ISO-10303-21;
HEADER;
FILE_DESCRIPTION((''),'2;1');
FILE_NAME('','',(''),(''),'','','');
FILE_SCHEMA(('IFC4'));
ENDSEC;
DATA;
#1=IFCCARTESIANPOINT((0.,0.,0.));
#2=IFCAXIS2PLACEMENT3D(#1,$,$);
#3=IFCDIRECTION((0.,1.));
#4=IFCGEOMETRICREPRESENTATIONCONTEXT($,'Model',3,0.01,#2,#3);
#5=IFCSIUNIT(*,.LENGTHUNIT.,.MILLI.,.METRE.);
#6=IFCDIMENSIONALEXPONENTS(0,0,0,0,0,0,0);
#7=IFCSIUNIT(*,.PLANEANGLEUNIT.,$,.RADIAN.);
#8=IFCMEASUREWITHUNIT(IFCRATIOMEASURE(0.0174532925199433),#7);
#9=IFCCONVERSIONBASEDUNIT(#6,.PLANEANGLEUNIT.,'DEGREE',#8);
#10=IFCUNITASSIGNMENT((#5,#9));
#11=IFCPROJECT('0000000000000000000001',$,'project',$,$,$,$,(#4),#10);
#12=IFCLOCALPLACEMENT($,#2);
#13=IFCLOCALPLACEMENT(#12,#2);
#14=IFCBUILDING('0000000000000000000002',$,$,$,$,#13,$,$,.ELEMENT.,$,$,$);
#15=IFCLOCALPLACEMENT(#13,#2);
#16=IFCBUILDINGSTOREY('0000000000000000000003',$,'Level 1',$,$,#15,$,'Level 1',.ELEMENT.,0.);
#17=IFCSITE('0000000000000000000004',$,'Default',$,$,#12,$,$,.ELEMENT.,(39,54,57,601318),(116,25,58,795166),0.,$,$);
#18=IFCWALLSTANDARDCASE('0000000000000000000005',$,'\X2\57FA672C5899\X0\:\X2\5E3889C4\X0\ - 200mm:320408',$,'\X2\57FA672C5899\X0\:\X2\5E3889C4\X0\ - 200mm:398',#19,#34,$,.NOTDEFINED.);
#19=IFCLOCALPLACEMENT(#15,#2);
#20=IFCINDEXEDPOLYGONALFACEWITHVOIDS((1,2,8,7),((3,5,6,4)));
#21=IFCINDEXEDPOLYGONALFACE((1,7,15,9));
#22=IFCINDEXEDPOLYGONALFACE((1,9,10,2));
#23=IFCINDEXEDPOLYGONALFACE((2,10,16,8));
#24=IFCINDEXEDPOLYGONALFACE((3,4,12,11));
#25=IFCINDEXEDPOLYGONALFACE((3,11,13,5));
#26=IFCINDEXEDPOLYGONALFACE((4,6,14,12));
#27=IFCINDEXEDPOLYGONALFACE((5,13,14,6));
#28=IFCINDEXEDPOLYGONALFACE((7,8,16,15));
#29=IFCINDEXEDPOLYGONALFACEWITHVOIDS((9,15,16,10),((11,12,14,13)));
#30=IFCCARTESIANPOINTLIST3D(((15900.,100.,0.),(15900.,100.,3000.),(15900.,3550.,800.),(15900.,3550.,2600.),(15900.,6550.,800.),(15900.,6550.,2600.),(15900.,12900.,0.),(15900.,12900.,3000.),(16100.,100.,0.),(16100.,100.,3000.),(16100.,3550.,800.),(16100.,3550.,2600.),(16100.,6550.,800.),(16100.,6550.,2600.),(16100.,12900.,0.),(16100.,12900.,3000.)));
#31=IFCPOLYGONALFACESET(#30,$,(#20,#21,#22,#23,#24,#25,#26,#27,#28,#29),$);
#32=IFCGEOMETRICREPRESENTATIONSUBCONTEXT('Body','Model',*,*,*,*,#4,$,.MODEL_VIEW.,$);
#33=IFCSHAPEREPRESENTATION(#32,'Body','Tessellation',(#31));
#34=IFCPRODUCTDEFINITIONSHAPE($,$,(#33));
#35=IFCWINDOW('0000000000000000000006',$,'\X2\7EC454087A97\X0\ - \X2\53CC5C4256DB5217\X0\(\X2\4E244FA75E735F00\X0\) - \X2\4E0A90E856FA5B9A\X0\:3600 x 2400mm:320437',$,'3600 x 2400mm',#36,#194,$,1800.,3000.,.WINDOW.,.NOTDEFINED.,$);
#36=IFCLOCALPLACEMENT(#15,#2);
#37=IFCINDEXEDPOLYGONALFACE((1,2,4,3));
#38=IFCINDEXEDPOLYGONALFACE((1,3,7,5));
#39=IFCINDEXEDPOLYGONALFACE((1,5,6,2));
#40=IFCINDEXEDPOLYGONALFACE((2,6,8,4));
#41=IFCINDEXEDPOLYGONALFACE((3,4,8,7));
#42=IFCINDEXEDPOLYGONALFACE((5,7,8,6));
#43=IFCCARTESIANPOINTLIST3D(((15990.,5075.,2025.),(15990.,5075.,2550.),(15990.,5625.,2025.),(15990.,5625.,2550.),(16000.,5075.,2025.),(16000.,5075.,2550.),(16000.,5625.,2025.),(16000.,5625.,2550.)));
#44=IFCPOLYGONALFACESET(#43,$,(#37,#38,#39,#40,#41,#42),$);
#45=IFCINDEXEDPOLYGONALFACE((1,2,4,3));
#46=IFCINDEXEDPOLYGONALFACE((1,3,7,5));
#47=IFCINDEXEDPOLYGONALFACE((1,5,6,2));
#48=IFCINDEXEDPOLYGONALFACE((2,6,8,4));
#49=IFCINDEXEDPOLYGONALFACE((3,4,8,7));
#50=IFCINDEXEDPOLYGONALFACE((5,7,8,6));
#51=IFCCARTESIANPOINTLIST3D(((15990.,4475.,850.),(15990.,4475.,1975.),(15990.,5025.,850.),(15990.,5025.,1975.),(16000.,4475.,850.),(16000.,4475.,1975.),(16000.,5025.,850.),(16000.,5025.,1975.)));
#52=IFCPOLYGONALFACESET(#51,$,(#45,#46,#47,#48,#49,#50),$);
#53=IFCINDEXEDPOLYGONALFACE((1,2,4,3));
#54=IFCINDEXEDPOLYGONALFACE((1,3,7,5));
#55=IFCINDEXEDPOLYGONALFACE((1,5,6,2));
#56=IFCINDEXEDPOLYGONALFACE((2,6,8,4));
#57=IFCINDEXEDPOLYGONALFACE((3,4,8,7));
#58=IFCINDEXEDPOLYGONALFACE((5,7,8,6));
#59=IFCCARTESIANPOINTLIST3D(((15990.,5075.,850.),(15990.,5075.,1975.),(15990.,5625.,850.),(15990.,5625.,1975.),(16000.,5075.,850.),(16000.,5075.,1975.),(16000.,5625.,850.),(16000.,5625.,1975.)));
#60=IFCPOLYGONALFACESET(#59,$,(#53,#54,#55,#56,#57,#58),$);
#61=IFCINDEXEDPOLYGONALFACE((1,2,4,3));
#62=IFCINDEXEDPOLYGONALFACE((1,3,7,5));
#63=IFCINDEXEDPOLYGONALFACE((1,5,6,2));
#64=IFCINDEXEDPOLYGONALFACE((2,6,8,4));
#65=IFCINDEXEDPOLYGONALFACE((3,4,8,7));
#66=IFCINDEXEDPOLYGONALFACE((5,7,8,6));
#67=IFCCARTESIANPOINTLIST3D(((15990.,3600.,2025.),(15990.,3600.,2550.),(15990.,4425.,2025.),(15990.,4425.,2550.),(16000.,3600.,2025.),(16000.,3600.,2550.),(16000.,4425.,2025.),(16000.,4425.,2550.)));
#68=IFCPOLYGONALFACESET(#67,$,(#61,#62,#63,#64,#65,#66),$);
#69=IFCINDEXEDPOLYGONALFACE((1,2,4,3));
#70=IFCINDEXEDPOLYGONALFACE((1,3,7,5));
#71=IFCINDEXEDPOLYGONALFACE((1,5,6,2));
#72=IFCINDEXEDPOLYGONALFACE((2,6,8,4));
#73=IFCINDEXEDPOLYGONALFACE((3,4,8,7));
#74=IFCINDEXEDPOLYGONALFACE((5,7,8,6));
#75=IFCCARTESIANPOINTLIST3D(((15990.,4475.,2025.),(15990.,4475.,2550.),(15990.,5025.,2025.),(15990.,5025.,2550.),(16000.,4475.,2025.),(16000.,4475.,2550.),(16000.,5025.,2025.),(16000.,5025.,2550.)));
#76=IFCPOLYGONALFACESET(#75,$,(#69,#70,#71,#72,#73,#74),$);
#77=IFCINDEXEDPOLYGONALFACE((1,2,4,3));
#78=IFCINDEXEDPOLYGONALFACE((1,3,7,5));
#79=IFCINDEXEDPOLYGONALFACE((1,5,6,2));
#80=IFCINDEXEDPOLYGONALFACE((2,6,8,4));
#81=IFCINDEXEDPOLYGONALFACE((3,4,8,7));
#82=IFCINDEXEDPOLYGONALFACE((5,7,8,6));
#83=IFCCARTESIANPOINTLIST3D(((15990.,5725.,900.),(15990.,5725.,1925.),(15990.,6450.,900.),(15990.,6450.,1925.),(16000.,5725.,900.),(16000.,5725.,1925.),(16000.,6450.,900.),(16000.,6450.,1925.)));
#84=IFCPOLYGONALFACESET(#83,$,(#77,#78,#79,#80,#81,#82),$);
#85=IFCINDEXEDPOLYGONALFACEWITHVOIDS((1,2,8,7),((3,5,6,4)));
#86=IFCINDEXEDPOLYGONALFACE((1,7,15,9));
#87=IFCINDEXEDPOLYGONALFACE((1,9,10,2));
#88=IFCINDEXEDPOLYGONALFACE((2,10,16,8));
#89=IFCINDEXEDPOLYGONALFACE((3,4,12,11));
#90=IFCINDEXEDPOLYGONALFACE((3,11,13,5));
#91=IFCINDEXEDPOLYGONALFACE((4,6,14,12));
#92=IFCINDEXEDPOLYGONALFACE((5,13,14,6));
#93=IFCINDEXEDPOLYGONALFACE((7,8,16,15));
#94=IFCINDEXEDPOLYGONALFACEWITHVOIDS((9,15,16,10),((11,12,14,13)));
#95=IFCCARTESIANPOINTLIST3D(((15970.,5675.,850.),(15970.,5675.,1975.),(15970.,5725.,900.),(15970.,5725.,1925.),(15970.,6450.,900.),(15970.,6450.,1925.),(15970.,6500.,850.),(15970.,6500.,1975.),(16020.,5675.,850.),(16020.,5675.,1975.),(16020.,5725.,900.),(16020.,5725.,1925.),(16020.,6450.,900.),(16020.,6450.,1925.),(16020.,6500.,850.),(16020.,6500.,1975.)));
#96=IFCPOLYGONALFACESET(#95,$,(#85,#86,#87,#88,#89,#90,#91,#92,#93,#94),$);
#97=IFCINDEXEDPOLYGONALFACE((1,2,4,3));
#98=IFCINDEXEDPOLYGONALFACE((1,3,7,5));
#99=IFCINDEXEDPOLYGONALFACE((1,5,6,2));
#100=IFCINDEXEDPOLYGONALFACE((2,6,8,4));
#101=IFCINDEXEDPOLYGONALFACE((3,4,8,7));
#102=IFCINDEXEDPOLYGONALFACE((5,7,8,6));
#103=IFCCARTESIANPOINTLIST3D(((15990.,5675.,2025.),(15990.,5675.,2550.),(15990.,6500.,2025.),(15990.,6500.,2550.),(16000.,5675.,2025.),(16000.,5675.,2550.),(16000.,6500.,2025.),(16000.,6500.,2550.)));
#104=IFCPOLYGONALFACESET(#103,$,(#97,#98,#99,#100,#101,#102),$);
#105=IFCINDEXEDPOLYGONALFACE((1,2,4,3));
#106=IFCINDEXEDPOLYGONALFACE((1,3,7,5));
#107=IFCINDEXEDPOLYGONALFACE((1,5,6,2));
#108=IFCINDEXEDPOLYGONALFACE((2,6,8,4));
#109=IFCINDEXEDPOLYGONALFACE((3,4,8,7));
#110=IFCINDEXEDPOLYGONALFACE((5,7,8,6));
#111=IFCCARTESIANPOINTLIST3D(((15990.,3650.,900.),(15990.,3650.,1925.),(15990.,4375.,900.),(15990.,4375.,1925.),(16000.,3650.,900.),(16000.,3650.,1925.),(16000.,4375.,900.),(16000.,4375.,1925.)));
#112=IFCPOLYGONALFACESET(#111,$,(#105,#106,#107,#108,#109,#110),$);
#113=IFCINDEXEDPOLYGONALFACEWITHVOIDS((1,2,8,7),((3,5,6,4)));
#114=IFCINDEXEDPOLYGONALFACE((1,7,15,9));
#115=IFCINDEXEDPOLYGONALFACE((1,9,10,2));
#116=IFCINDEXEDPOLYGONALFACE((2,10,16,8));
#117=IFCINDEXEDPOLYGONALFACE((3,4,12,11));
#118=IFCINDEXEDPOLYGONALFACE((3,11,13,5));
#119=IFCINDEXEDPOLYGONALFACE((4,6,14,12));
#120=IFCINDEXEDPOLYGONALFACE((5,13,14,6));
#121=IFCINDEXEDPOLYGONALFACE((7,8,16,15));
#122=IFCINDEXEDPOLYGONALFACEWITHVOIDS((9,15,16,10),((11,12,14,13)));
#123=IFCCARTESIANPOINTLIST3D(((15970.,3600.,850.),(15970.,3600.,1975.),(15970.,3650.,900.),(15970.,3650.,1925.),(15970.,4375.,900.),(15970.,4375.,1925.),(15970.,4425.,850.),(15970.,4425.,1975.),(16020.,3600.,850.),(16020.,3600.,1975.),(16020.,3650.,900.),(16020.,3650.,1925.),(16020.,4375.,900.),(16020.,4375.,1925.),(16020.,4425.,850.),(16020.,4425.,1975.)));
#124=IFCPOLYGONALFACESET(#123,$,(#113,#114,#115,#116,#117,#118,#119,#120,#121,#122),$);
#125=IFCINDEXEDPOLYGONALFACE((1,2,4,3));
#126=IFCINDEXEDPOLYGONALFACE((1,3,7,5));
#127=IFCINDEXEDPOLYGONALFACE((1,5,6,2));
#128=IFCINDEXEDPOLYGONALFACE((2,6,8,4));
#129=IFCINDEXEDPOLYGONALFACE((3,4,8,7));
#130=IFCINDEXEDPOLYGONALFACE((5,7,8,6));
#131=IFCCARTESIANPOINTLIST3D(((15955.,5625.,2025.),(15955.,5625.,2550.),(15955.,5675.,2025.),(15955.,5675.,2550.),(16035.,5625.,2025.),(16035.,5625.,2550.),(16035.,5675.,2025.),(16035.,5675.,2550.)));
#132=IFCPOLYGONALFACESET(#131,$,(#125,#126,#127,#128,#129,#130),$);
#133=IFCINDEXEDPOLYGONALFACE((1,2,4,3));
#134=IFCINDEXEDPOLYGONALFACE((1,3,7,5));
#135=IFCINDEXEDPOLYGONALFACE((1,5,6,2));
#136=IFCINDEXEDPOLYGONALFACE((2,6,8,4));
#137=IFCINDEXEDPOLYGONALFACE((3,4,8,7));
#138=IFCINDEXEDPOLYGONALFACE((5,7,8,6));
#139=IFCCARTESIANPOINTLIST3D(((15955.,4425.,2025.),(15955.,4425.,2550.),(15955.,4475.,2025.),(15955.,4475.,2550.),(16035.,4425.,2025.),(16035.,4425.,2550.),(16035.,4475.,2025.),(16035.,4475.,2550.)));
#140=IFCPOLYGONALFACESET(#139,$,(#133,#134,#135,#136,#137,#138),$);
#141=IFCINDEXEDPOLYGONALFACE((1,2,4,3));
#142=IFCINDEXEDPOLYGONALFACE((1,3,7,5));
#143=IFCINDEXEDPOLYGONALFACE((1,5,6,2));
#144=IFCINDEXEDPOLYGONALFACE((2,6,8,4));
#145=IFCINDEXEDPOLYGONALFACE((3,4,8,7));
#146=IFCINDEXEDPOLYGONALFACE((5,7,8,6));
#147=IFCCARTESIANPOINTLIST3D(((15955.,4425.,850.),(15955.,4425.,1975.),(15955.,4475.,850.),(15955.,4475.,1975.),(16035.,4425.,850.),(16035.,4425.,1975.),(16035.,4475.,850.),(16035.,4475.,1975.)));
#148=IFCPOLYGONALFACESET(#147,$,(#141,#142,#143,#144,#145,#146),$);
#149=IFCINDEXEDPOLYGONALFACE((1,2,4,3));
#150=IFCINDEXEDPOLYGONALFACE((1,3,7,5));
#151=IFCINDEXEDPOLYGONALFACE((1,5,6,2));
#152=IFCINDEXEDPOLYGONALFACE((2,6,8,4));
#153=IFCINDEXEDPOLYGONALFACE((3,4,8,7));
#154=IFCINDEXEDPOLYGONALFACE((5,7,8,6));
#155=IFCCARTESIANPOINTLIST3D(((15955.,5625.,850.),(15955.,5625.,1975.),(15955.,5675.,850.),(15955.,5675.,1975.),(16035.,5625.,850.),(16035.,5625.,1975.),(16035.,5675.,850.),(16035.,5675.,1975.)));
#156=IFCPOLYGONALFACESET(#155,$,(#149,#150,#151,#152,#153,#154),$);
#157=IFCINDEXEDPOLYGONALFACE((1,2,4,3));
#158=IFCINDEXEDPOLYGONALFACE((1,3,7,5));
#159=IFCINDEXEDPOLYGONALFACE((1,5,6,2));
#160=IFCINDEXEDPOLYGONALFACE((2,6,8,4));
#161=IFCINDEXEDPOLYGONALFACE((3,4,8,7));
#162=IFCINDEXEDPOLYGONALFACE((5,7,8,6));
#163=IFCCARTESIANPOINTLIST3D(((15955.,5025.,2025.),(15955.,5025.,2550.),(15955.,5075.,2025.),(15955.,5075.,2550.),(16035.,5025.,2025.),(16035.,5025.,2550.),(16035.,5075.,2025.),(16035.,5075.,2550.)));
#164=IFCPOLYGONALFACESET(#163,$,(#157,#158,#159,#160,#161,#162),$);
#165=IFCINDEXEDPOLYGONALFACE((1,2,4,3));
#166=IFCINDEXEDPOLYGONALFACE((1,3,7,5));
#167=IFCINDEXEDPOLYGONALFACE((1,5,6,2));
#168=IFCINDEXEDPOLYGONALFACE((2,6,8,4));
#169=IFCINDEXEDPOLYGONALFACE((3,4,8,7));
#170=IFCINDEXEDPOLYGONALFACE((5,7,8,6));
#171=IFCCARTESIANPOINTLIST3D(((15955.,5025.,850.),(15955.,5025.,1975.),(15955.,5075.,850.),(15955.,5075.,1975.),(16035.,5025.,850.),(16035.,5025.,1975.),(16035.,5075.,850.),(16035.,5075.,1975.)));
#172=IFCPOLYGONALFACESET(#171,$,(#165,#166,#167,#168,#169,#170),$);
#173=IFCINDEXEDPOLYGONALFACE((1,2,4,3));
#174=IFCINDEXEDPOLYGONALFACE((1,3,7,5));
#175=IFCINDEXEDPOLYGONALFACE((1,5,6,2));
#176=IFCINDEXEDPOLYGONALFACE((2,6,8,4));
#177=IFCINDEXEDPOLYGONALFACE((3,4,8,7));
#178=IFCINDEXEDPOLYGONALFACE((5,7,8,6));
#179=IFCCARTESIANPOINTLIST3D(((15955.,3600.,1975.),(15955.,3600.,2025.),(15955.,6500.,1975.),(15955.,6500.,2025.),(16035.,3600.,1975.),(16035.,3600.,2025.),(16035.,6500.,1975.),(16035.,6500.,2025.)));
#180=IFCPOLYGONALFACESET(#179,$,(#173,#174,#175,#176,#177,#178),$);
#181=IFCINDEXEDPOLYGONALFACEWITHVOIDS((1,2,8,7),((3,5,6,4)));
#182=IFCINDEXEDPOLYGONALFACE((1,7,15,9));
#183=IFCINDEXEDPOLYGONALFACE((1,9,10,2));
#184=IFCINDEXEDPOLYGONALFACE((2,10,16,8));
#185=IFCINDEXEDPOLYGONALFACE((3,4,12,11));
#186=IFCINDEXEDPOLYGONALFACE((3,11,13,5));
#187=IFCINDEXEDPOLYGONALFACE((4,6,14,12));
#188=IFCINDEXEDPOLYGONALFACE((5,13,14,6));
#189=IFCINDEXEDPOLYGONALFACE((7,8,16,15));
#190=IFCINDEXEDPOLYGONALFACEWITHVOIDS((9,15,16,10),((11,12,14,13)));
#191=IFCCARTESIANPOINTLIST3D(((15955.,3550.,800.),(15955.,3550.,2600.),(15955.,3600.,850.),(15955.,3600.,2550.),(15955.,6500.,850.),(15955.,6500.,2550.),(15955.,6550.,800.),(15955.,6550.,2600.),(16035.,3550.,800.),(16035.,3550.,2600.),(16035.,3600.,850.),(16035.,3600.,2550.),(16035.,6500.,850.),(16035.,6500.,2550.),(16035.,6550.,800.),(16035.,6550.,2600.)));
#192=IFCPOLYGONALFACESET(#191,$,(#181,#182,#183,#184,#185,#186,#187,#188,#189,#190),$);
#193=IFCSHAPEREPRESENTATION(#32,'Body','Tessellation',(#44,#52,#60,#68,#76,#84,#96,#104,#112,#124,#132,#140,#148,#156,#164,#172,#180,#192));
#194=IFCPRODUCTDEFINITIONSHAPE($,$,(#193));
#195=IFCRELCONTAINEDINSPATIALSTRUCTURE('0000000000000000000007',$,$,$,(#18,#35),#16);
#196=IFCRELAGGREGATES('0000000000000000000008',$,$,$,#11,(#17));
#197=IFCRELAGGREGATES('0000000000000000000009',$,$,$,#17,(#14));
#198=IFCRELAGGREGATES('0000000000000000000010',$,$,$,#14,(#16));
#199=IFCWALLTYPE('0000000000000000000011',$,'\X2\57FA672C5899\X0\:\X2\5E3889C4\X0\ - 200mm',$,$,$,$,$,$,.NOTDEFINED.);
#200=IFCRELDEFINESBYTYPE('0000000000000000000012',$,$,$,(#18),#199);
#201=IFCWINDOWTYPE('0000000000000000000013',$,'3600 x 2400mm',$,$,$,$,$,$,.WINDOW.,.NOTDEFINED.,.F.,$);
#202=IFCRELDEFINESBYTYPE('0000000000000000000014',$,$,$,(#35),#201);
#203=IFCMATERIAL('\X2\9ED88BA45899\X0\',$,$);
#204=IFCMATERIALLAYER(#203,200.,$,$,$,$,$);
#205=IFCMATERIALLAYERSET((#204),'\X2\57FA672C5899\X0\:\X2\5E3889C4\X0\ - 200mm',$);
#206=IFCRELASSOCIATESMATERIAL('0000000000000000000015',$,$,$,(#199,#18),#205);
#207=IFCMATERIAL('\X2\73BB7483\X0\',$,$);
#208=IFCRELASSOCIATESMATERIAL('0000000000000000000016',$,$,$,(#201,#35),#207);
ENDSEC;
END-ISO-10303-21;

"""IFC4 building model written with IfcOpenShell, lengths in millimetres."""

from ifc_helpers import new_model, entity, si_unit, converted_unit, direction, frame, frame_2d, origin, origin_2d_with_axis, place, context, subcontext, project, spatial, polyline, rectangle, outline, extrude, source, transform, mapped, material, layer, layer_set, layer_usage, type_object, type_shapes, element, fill, save


model = new_model("IFC4")

# Units and contexts
model_context = context("Model", 3, precision=0.01, world=origin(), true_north=direction((0.0, 1.0)))
body_context = subcontext(model_context, "Body", "Model", "MODEL_VIEW")
ifc_project = project(units=[si_unit("LENGTHUNIT", "METRE", prefix="MILLI"), converted_unit("PLANEANGLEUNIT", "DEGREE", entity("IfcRatioMeasure", 0.0174532925199433), si_unit("PLANEANGLEUNIT", "RADIAN"), dimensions=[0, 0, 0, 0, 0, 0, 0])], contexts=[model_context])

# Site, building, storey
site_placement = place(None, origin())
site = spatial("IfcSite", under=ifc_project, at=site_placement, Name="Default", CompositionType="ELEMENT", RefLatitude=(39, 54, 57, 601318), RefLongitude=(116, 25, 58, 795166), RefElevation=0.0)
building_placement = place(site_placement, origin())
building = spatial("IfcBuilding", under=site, at=building_placement, CompositionType="ELEMENT")
storey_placement = place(building_placement, origin())
storey = spatial("IfcBuildingStorey", under=building, at=storey_placement, Name="Level 1", LongName="Level 1", CompositionType="ELEMENT", Elevation=0.0)

# Shared definitions
ifc_material_1 = material(Name="默认墙")
ifc_layer = layer(ifc_material_1, 200.0)
ifc_layer_set = layer_set([ifc_layer], Name="基本墙:常规 - 200mm")
wall_type = type_object("IfcWallType", Name="基本墙:常规 - 200mm", PredefinedType="NOTDEFINED", material=ifc_layer_set)
ifc_material_2 = material(Name="玻璃")
window_type = type_object("IfcWindowType", Name="3600 x 2400mm", ParameterTakesPrecedence=False, PartitioningType="NOTDEFINED", PredefinedType="WINDOW", material=ifc_material_2)
shared_shape_1 = source(origin(), body_context, "Body", "SweptSolid", [
    extrude(rectangle(XDim=10.0, YDim=550.0, at=origin_2d_with_axis()), frame((1200.0, 95.0, 1225.0), z_axis=(0.0, 0.0, 1.0), x_axis=(0.0, 1.0, 0.0)), (0.0, 0.0, 1.0), 525.0),
    extrude(rectangle(XDim=10.0, YDim=550.0, at=origin_2d_with_axis()), frame((1800.0, 95.0, 50.0), z_axis=(0.0, 0.0, 1.0), x_axis=(0.0, 1.0, 0.0)), (0.0, 0.0, 1.0), 1125.0),
    extrude(rectangle(XDim=10.0, YDim=550.0, at=origin_2d_with_axis()), frame((1200.0, 95.0, 50.0), z_axis=(0.0, 0.0, 1.0), x_axis=(0.0, 1.0, 0.0)), (0.0, 0.0, 1.0), 1125.0),
    extrude(rectangle(XDim=10.0, YDim=825.0, at=origin_2d_with_axis()), frame((2537.5, 95.0, 1225.0), z_axis=(0.0, 0.0, 1.0), x_axis=(0.0, 1.0, 0.0)), (0.0, 0.0, 1.0), 525.0),
    extrude(rectangle(XDim=10.0, YDim=550.0, at=origin_2d_with_axis()), frame((1800.0, 95.0, 1225.0), z_axis=(0.0, 0.0, 1.0), x_axis=(0.0, 1.0, 0.0)), (0.0, 0.0, 1.0), 525.0),
    extrude(rectangle(XDim=10.0, YDim=725.0, at=origin_2d_with_axis()), frame((462.5, 95.0, 100.0), z_axis=(0.0, 0.0, 1.0), x_axis=(0.0, 1.0, 0.0)), (0.0, 0.0, 1.0), 1025.0),
    extrude(outline(polyline([(-562.5, -412.5), (562.5, -412.5), (562.5, 412.5), (-562.5, 412.5), (-562.5, -412.5)]), holes=[polyline([(512.5, -362.5), (-512.5, -362.5), (-512.5, 362.5), (512.5, 362.5), (512.5, -362.5)])]), frame((462.5, 70.0, 612.5), z_axis=(0.0, 1.0, 0.0), x_axis=(0.0, 0.0, -1.0)), (0.0, 0.0, 1.0), 50.0),
    extrude(rectangle(XDim=10.0, YDim=825.0, at=origin_2d_with_axis()), frame((462.5, 95.0, 1225.0), z_axis=(0.0, 0.0, 1.0), x_axis=(0.0, 1.0, 0.0)), (0.0, 0.0, 1.0), 525.0),
    extrude(rectangle(XDim=10.0, YDim=725.0, at=origin_2d_with_axis()), frame((2537.5, 95.0, 100.0), z_axis=(0.0, 0.0, 1.0), x_axis=(0.0, 1.0, 0.0)), (0.0, 0.0, 1.0), 1025.0),
    extrude(outline(polyline([(-562.5, -412.5), (562.5, -412.5), (562.5, 412.5), (-562.5, 412.5), (-562.5, -412.5)]), holes=[polyline([(512.5, -362.5), (-512.5, -362.5), (-512.5, 362.5), (512.5, 362.5), (512.5, -362.5)])]), frame((2537.5, 70.0, 612.5), z_axis=(0.0, 1.0, 0.0), x_axis=(0.0, 0.0, -1.0)), (0.0, 0.0, 1.0), 50.0),
    extrude(rectangle(XDim=80.0, YDim=50.0, at=origin_2d_with_axis()), frame((900.0, 95.0, 1225.0), z_axis=(0.0, 0.0, 1.0), x_axis=(0.0, -1.0, 0.0)), (0.0, 0.0, 1.0), 525.0),
    extrude(rectangle(XDim=80.0, YDim=50.0, at=origin_2d_with_axis()), frame((2100.0, 95.0, 1225.0), z_axis=(0.0, 0.0, 1.0), x_axis=(0.0, -1.0, 0.0)), (0.0, 0.0, 1.0), 525.0),
    extrude(rectangle(XDim=80.0, YDim=50.0, at=origin_2d_with_axis()), frame((2100.0, 95.0, 50.0), z_axis=(0.0, 0.0, 1.0), x_axis=(0.0, -1.0, 0.0)), (0.0, 0.0, 1.0), 1125.0),
    extrude(rectangle(XDim=80.0, YDim=50.0, at=origin_2d_with_axis()), frame((900.0, 95.0, 50.0), z_axis=(0.0, 0.0, 1.0), x_axis=(0.0, -1.0, 0.0)), (0.0, 0.0, 1.0), 1125.0),
    extrude(rectangle(XDim=80.0, YDim=50.0, at=origin_2d_with_axis()), frame((1500.0, 95.0, 1225.0), z_axis=(0.0, 0.0, 1.0), x_axis=(0.0, -1.0, 0.0)), (0.0, 0.0, 1.0), 525.0),
    extrude(rectangle(XDim=80.0, YDim=50.0, at=origin_2d_with_axis()), frame((1500.0, 95.0, 50.0), z_axis=(0.0, 0.0, 1.0), x_axis=(0.0, -1.0, 0.0)), (0.0, 0.0, 1.0), 1125.0),
    extrude(rectangle(XDim=80.0, YDim=2900.0, at=origin_2d_with_axis()), frame((1500.0, 95.0, 1175.0), z_axis=(0.0, 0.0, 1.0), x_axis=(0.0, -1.0, 0.0)), (0.0, 0.0, 1.0), 50.0),
    extrude(outline(polyline([(-1500.0, -900.0), (1500.0, -900.0), (1500.0, 900.0), (-1500.0, 900.0), (-1500.0, -900.0)]), holes=[polyline([(1450.0, -850.0), (-1450.0, -850.0), (-1450.0, 850.0), (1450.0, 850.0), (1450.0, -850.0)])]), frame((1500.0, 55.0, 900.0), z_axis=(0.0, 1.0, 0.0), x_axis=(1.0, 0.0, 0.0)), (0.0, 0.0, 1.0), 80.0),
])
type_shapes(window_type, [shared_shape_1])

# Wall, opening, window
ifc_layer_usage_1 = layer_usage(ifc_layer_set, "AXIS2", "NEGATIVE", 100.0)
wall_1_placement = place(storey_placement, frame((16000.0, 12900.0, 0.0), z_axis=(0.0, 0.0, 1.0), x_axis=(0.0, -1.0, 0.0)))
wall_1 = element("IfcWallStandardCase", 1, at=wall_1_placement, inside=storey, type_object=wall_type, material=ifc_layer_usage_1, Name="基本墙:常规 - 200mm:320408", ObjectType="基本墙:常规 - 200mm:398", PredefinedType="NOTDEFINED", context=body_context, shape_type="SweptSolid", body=[
    extrude(rectangle(XDim=12800.0, YDim=200.0, at=frame_2d((6400.0, 0.0), x_axis=(-1.0, 0.0))), origin(), (0.0, 0.0, 1.0), 3000.0),
])
opening_1_placement = place(wall_1_placement, frame((6350.0, -100.0, 800.0)))
opening_1 = element("IfcOpeningElement", 2, at=opening_1_placement, cuts=wall_1, ObjectType="Opening", PredefinedType="OPENING", context=body_context, shape_type="SweptSolid", body=[
    extrude(rectangle(XDim=1800.0, YDim=3000.0, at=frame_2d((900.0, 1500.0), x_axis=(1.0, 0.0))), frame((0.0, 0.0, 0.0), z_axis=(0.0, 1.0, 0.0), x_axis=(0.0, 0.0, 1.0)), (0.0, 0.0, 1.0), 200.0),
])
window_1_placement = place(opening_1_placement, origin())
window_1 = element("IfcWindow", 3, at=window_1_placement, inside=storey, type_object=window_type, material=ifc_material_2, Name="组合窗 - 双层四列(两侧平开) - 上部固定:3600 x 2400mm:320437", ObjectType="3600 x 2400mm", OverallHeight=1800.0, OverallWidth=3000.0, PartitioningType="NOTDEFINED", PredefinedType="WINDOW", context=body_context, shape_type="MappedRepresentation", body=[
    mapped(shared_shape_1, transform((0.0, 0.0, 0.0), scale=1.0)),
])
fill(opening_1, window_1)

save(model, "model.ifc")
